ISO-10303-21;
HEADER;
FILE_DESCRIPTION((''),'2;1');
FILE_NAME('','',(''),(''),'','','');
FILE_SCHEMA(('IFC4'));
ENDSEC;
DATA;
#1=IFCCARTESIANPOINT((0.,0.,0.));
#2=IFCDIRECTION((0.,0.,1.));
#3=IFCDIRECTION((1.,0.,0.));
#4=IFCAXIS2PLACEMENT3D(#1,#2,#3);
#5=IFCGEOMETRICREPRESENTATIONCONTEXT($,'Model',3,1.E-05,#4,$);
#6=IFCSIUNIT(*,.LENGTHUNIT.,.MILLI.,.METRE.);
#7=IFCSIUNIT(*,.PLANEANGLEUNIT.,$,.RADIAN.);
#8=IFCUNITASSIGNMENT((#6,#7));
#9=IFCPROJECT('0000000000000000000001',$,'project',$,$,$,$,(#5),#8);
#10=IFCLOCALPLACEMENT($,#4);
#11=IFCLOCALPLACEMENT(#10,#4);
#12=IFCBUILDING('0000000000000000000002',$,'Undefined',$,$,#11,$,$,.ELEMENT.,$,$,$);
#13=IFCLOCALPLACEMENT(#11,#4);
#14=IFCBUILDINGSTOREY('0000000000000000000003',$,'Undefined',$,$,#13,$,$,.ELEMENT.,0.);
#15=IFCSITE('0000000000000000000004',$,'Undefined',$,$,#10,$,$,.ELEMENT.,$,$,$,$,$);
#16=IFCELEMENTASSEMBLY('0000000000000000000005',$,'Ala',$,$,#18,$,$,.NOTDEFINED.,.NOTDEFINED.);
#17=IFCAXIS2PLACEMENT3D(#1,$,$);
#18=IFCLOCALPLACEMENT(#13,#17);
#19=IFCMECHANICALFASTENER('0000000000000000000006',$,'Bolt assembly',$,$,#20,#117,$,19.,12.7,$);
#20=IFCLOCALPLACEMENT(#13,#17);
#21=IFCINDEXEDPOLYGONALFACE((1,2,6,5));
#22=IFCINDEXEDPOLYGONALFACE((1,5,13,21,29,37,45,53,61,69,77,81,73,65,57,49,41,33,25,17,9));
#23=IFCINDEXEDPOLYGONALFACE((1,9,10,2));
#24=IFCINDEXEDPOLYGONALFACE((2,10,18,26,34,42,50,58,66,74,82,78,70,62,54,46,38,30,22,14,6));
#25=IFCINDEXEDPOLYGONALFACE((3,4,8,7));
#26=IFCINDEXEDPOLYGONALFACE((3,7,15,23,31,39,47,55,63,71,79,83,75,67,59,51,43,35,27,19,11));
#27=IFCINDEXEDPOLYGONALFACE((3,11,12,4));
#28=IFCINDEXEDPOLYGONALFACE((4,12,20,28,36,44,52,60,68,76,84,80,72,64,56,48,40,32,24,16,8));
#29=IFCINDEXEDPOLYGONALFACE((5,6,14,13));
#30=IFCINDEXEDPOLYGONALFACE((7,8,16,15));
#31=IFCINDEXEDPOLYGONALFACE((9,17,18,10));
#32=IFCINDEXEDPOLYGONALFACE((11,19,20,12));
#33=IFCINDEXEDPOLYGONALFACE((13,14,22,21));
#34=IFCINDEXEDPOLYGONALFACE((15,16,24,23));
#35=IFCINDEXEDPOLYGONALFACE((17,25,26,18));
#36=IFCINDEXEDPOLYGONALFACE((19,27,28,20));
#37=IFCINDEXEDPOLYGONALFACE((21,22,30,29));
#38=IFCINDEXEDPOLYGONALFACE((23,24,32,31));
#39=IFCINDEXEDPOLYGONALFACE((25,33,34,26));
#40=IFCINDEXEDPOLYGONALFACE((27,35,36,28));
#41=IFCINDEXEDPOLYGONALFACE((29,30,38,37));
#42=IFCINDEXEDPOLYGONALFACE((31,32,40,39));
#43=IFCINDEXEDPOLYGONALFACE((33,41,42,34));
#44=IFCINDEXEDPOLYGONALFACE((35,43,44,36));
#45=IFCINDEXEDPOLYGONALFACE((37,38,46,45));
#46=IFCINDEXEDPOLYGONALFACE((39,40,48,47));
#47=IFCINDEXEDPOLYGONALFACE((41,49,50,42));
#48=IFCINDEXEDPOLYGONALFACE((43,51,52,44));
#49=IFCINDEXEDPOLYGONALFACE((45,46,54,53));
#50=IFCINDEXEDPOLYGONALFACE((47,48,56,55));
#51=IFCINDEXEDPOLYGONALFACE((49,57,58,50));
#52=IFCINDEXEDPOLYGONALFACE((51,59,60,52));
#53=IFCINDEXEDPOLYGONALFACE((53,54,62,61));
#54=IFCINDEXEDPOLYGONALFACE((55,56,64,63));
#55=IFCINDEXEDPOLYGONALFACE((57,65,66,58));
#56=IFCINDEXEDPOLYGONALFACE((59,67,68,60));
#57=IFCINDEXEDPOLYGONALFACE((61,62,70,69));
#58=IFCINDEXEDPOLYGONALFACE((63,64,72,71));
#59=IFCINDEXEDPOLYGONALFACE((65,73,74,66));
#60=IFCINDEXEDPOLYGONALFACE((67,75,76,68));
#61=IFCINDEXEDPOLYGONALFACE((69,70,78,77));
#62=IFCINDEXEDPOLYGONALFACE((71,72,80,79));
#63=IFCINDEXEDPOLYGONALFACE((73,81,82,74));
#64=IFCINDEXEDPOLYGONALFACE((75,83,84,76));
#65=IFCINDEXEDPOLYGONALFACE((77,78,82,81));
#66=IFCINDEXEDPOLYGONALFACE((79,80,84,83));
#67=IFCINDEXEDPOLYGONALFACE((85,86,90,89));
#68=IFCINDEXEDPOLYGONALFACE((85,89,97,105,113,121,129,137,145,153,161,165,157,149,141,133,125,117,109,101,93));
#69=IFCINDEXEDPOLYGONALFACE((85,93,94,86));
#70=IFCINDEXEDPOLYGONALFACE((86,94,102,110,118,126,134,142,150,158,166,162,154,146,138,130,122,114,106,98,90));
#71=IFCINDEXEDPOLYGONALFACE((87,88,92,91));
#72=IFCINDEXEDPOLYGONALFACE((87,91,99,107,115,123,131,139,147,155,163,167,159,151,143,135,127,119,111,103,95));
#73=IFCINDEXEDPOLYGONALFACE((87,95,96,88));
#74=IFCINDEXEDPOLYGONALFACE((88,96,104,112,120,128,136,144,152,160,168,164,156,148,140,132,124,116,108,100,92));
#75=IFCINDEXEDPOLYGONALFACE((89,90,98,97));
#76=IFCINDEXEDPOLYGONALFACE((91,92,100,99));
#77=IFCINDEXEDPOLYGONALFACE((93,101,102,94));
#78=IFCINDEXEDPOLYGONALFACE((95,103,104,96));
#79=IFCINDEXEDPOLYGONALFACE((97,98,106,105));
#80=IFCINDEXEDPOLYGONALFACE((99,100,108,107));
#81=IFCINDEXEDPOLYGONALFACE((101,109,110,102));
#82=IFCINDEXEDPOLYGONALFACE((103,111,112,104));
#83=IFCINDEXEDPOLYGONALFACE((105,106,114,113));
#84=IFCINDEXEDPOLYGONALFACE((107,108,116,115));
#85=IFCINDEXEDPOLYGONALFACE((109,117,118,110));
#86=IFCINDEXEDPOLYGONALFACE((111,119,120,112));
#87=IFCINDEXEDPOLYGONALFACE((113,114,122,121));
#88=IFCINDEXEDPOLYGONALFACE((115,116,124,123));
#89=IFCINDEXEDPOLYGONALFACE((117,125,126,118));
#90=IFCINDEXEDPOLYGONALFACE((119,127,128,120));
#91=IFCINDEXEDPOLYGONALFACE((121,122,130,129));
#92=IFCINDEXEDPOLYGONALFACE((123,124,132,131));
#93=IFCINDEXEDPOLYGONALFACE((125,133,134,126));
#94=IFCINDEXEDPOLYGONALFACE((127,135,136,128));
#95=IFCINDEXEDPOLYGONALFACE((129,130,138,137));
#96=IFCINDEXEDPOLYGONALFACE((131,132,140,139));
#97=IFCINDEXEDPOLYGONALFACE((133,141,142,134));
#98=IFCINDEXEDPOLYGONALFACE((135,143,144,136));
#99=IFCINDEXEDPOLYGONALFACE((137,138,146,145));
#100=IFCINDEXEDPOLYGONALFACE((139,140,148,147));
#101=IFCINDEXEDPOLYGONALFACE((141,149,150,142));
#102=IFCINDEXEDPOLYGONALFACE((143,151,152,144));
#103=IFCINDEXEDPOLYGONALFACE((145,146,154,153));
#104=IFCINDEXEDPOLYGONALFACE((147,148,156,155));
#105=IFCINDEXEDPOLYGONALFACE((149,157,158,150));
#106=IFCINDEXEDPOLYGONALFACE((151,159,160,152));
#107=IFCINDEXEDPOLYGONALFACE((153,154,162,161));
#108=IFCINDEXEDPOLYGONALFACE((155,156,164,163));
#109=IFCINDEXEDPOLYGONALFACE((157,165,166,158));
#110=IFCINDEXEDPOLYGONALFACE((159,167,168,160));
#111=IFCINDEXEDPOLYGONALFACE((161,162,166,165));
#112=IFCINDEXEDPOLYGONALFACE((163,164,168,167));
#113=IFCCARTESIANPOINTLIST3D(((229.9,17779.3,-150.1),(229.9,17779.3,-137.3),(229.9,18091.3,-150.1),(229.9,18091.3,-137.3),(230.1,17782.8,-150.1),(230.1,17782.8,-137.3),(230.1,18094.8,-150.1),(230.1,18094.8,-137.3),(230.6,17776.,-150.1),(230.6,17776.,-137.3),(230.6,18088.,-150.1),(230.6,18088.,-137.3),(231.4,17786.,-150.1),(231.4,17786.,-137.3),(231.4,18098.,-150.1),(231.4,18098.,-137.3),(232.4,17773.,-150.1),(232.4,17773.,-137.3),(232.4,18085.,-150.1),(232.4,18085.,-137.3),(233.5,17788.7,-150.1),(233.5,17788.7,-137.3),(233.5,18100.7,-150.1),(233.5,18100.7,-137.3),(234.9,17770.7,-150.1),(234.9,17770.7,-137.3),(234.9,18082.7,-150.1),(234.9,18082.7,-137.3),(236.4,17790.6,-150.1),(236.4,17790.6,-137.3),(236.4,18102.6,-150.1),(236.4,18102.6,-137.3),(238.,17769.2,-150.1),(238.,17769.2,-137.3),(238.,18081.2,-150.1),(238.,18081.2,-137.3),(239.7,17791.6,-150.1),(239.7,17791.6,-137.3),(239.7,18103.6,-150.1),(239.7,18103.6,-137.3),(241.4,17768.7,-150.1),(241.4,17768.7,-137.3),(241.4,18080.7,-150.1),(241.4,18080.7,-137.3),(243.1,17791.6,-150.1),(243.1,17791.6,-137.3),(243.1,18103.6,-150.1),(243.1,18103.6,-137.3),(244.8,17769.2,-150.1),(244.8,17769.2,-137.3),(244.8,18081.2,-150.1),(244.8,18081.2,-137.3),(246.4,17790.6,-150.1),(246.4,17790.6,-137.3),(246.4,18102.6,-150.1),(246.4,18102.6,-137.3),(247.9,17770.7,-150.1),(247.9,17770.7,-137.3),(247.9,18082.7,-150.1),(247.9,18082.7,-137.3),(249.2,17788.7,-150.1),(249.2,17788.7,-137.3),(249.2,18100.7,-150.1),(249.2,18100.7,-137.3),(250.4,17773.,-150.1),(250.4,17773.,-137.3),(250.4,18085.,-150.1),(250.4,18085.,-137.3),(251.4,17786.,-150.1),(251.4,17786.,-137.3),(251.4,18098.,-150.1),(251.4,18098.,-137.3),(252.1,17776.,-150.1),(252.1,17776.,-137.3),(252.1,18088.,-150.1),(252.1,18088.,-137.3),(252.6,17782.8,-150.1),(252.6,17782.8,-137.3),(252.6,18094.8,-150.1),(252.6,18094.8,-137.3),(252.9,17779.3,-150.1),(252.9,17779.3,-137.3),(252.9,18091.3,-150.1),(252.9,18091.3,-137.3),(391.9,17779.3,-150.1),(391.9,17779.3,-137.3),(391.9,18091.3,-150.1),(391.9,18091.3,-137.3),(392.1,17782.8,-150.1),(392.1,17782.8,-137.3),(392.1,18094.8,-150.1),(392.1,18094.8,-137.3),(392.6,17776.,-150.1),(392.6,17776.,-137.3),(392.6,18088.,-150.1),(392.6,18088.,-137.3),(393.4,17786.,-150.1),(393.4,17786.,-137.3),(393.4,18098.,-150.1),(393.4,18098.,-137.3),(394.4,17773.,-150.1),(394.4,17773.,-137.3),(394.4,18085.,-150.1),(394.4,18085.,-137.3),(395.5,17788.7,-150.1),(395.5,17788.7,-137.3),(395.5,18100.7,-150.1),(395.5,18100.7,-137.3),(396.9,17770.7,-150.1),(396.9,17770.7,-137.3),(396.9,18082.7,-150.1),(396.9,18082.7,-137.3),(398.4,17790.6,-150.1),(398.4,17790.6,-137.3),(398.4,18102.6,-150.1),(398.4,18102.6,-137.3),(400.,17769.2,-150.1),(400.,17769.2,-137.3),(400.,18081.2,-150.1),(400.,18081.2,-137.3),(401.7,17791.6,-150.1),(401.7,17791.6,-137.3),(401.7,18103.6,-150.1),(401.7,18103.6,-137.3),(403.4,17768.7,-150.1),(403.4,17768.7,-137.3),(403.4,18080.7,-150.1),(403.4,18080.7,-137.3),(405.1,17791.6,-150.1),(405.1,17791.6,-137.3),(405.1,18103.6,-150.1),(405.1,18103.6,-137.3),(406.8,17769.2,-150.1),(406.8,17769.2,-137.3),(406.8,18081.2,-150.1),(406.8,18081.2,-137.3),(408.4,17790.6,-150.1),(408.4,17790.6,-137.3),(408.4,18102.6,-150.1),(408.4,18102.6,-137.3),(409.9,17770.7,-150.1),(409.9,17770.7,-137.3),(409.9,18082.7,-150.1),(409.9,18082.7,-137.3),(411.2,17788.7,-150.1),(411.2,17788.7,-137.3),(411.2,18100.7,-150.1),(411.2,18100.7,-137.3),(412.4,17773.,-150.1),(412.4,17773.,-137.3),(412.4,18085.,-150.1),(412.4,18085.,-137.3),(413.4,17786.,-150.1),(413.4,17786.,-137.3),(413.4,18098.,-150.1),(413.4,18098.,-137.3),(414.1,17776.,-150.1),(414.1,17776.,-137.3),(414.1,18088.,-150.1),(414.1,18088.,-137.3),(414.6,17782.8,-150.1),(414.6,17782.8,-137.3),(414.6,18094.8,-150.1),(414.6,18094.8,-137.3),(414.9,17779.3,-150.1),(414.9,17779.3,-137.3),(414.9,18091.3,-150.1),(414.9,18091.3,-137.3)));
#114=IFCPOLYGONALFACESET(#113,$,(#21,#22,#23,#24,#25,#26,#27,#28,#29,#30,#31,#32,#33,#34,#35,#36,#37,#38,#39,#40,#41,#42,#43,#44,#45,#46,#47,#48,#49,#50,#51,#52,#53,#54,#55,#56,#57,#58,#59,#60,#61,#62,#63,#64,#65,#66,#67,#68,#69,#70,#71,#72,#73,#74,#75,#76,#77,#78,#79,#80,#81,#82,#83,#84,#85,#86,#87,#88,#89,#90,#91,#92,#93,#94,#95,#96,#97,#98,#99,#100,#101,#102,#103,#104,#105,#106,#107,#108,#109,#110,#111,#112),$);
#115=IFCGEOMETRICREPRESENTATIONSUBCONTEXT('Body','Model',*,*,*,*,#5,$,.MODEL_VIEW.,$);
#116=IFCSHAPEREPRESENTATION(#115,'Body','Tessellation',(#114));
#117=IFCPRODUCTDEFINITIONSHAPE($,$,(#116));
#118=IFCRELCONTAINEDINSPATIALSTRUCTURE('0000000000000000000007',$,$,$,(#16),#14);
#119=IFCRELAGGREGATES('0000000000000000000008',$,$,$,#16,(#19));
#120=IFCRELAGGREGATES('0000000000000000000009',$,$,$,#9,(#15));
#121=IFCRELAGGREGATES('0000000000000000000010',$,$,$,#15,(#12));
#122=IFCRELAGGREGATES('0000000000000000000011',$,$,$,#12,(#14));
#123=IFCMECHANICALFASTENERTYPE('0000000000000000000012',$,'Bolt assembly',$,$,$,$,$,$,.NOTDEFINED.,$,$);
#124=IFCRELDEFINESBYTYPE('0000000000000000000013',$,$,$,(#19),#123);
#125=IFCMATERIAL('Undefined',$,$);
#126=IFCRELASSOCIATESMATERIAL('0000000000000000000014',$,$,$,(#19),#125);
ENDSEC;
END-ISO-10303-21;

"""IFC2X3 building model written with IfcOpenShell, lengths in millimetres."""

from ifc_helpers import new_model, si_unit, frame, origin_with_axes, origin_2d_with_axis, place, context, subcontext, project, spatial, circle, extrude, source, transform, mapped, material, type_object, element, aggregate, save


model = new_model("IFC2X3")

# Units and contexts
model_context = context("Model", 3, precision=1e-05, world=origin_with_axes())
body_context = subcontext(model_context, "Body", "Model", "MODEL_VIEW")
ifc_project = project(units=[si_unit("LENGTHUNIT", "METRE", prefix="MILLI"), si_unit("PLANEANGLEUNIT", "RADIAN")], contexts=[model_context])

# Site, building, storey
site_placement = place(None, origin_with_axes())
site = spatial("IfcSite", under=ifc_project, at=site_placement, Name="Undefined", CompositionType="ELEMENT")
building_placement = place(site_placement, origin_with_axes())
building = spatial("IfcBuilding", under=site, at=building_placement, Name="Undefined", CompositionType="ELEMENT")
storey_placement = place(building_placement, origin_with_axes())
storey = spatial("IfcBuildingStorey", under=building, at=storey_placement, Name="Undefined", CompositionType="ELEMENT", Elevation=0.0)

# Element assembly
assembly_1_placement = place(storey_placement, origin_with_axes())
assembly_1 = element("IfcElementAssembly", 1, at=assembly_1_placement, inside=storey, Name="Ala", AssemblyPlace="NOTDEFINED", PredefinedType="NOTDEFINED")

# Mechanical fastener
ifc_material_1 = material(Name="Undefined")
mechanical_fastener_type = type_object("IfcMechanicalFastenerType", Name="Bolt assembly")
shared_shape_1 = source(origin_with_axes(), body_context, "Body", "SweptSolid", [
    extrude(circle(Radius=11.5, at=origin_2d_with_axis()), frame((0.0, 0.0, 0.0), z_axis=(0.0, 1.0, 0.0), x_axis=(1.0, 0.0, 0.0)), (0.0, 0.0, 1.0), 12.8),
])
mechanical_fastener_1_placement = place(assembly_1_placement, frame((322.4, 18092.2, -137.3), z_axis=(1.0, 0.0, 0.0), x_axis=(0.0, -1.0, 0.0)))
mechanical_fastener_1 = element("IfcMechanicalFastener", 2, at=mechanical_fastener_1_placement, type_object=mechanical_fastener_type, material=ifc_material_1, Name="Bolt assembly", NominalDiameter=19.0, NominalLength=12.7, context=body_context, shape_type="MappedRepresentation", body=[
    mapped(shared_shape_1, transform((0.0, 0.0, -81.0))),
    mapped(shared_shape_1, transform((312.0, 0.0, -81.0))),
    mapped(shared_shape_1, transform((0.0, 0.0, 81.0))),
    mapped(shared_shape_1, transform((312.0, 0.0, 81.0))),
])
aggregate(assembly_1, [mechanical_fastener_1])

save(model, "model.ifc")
